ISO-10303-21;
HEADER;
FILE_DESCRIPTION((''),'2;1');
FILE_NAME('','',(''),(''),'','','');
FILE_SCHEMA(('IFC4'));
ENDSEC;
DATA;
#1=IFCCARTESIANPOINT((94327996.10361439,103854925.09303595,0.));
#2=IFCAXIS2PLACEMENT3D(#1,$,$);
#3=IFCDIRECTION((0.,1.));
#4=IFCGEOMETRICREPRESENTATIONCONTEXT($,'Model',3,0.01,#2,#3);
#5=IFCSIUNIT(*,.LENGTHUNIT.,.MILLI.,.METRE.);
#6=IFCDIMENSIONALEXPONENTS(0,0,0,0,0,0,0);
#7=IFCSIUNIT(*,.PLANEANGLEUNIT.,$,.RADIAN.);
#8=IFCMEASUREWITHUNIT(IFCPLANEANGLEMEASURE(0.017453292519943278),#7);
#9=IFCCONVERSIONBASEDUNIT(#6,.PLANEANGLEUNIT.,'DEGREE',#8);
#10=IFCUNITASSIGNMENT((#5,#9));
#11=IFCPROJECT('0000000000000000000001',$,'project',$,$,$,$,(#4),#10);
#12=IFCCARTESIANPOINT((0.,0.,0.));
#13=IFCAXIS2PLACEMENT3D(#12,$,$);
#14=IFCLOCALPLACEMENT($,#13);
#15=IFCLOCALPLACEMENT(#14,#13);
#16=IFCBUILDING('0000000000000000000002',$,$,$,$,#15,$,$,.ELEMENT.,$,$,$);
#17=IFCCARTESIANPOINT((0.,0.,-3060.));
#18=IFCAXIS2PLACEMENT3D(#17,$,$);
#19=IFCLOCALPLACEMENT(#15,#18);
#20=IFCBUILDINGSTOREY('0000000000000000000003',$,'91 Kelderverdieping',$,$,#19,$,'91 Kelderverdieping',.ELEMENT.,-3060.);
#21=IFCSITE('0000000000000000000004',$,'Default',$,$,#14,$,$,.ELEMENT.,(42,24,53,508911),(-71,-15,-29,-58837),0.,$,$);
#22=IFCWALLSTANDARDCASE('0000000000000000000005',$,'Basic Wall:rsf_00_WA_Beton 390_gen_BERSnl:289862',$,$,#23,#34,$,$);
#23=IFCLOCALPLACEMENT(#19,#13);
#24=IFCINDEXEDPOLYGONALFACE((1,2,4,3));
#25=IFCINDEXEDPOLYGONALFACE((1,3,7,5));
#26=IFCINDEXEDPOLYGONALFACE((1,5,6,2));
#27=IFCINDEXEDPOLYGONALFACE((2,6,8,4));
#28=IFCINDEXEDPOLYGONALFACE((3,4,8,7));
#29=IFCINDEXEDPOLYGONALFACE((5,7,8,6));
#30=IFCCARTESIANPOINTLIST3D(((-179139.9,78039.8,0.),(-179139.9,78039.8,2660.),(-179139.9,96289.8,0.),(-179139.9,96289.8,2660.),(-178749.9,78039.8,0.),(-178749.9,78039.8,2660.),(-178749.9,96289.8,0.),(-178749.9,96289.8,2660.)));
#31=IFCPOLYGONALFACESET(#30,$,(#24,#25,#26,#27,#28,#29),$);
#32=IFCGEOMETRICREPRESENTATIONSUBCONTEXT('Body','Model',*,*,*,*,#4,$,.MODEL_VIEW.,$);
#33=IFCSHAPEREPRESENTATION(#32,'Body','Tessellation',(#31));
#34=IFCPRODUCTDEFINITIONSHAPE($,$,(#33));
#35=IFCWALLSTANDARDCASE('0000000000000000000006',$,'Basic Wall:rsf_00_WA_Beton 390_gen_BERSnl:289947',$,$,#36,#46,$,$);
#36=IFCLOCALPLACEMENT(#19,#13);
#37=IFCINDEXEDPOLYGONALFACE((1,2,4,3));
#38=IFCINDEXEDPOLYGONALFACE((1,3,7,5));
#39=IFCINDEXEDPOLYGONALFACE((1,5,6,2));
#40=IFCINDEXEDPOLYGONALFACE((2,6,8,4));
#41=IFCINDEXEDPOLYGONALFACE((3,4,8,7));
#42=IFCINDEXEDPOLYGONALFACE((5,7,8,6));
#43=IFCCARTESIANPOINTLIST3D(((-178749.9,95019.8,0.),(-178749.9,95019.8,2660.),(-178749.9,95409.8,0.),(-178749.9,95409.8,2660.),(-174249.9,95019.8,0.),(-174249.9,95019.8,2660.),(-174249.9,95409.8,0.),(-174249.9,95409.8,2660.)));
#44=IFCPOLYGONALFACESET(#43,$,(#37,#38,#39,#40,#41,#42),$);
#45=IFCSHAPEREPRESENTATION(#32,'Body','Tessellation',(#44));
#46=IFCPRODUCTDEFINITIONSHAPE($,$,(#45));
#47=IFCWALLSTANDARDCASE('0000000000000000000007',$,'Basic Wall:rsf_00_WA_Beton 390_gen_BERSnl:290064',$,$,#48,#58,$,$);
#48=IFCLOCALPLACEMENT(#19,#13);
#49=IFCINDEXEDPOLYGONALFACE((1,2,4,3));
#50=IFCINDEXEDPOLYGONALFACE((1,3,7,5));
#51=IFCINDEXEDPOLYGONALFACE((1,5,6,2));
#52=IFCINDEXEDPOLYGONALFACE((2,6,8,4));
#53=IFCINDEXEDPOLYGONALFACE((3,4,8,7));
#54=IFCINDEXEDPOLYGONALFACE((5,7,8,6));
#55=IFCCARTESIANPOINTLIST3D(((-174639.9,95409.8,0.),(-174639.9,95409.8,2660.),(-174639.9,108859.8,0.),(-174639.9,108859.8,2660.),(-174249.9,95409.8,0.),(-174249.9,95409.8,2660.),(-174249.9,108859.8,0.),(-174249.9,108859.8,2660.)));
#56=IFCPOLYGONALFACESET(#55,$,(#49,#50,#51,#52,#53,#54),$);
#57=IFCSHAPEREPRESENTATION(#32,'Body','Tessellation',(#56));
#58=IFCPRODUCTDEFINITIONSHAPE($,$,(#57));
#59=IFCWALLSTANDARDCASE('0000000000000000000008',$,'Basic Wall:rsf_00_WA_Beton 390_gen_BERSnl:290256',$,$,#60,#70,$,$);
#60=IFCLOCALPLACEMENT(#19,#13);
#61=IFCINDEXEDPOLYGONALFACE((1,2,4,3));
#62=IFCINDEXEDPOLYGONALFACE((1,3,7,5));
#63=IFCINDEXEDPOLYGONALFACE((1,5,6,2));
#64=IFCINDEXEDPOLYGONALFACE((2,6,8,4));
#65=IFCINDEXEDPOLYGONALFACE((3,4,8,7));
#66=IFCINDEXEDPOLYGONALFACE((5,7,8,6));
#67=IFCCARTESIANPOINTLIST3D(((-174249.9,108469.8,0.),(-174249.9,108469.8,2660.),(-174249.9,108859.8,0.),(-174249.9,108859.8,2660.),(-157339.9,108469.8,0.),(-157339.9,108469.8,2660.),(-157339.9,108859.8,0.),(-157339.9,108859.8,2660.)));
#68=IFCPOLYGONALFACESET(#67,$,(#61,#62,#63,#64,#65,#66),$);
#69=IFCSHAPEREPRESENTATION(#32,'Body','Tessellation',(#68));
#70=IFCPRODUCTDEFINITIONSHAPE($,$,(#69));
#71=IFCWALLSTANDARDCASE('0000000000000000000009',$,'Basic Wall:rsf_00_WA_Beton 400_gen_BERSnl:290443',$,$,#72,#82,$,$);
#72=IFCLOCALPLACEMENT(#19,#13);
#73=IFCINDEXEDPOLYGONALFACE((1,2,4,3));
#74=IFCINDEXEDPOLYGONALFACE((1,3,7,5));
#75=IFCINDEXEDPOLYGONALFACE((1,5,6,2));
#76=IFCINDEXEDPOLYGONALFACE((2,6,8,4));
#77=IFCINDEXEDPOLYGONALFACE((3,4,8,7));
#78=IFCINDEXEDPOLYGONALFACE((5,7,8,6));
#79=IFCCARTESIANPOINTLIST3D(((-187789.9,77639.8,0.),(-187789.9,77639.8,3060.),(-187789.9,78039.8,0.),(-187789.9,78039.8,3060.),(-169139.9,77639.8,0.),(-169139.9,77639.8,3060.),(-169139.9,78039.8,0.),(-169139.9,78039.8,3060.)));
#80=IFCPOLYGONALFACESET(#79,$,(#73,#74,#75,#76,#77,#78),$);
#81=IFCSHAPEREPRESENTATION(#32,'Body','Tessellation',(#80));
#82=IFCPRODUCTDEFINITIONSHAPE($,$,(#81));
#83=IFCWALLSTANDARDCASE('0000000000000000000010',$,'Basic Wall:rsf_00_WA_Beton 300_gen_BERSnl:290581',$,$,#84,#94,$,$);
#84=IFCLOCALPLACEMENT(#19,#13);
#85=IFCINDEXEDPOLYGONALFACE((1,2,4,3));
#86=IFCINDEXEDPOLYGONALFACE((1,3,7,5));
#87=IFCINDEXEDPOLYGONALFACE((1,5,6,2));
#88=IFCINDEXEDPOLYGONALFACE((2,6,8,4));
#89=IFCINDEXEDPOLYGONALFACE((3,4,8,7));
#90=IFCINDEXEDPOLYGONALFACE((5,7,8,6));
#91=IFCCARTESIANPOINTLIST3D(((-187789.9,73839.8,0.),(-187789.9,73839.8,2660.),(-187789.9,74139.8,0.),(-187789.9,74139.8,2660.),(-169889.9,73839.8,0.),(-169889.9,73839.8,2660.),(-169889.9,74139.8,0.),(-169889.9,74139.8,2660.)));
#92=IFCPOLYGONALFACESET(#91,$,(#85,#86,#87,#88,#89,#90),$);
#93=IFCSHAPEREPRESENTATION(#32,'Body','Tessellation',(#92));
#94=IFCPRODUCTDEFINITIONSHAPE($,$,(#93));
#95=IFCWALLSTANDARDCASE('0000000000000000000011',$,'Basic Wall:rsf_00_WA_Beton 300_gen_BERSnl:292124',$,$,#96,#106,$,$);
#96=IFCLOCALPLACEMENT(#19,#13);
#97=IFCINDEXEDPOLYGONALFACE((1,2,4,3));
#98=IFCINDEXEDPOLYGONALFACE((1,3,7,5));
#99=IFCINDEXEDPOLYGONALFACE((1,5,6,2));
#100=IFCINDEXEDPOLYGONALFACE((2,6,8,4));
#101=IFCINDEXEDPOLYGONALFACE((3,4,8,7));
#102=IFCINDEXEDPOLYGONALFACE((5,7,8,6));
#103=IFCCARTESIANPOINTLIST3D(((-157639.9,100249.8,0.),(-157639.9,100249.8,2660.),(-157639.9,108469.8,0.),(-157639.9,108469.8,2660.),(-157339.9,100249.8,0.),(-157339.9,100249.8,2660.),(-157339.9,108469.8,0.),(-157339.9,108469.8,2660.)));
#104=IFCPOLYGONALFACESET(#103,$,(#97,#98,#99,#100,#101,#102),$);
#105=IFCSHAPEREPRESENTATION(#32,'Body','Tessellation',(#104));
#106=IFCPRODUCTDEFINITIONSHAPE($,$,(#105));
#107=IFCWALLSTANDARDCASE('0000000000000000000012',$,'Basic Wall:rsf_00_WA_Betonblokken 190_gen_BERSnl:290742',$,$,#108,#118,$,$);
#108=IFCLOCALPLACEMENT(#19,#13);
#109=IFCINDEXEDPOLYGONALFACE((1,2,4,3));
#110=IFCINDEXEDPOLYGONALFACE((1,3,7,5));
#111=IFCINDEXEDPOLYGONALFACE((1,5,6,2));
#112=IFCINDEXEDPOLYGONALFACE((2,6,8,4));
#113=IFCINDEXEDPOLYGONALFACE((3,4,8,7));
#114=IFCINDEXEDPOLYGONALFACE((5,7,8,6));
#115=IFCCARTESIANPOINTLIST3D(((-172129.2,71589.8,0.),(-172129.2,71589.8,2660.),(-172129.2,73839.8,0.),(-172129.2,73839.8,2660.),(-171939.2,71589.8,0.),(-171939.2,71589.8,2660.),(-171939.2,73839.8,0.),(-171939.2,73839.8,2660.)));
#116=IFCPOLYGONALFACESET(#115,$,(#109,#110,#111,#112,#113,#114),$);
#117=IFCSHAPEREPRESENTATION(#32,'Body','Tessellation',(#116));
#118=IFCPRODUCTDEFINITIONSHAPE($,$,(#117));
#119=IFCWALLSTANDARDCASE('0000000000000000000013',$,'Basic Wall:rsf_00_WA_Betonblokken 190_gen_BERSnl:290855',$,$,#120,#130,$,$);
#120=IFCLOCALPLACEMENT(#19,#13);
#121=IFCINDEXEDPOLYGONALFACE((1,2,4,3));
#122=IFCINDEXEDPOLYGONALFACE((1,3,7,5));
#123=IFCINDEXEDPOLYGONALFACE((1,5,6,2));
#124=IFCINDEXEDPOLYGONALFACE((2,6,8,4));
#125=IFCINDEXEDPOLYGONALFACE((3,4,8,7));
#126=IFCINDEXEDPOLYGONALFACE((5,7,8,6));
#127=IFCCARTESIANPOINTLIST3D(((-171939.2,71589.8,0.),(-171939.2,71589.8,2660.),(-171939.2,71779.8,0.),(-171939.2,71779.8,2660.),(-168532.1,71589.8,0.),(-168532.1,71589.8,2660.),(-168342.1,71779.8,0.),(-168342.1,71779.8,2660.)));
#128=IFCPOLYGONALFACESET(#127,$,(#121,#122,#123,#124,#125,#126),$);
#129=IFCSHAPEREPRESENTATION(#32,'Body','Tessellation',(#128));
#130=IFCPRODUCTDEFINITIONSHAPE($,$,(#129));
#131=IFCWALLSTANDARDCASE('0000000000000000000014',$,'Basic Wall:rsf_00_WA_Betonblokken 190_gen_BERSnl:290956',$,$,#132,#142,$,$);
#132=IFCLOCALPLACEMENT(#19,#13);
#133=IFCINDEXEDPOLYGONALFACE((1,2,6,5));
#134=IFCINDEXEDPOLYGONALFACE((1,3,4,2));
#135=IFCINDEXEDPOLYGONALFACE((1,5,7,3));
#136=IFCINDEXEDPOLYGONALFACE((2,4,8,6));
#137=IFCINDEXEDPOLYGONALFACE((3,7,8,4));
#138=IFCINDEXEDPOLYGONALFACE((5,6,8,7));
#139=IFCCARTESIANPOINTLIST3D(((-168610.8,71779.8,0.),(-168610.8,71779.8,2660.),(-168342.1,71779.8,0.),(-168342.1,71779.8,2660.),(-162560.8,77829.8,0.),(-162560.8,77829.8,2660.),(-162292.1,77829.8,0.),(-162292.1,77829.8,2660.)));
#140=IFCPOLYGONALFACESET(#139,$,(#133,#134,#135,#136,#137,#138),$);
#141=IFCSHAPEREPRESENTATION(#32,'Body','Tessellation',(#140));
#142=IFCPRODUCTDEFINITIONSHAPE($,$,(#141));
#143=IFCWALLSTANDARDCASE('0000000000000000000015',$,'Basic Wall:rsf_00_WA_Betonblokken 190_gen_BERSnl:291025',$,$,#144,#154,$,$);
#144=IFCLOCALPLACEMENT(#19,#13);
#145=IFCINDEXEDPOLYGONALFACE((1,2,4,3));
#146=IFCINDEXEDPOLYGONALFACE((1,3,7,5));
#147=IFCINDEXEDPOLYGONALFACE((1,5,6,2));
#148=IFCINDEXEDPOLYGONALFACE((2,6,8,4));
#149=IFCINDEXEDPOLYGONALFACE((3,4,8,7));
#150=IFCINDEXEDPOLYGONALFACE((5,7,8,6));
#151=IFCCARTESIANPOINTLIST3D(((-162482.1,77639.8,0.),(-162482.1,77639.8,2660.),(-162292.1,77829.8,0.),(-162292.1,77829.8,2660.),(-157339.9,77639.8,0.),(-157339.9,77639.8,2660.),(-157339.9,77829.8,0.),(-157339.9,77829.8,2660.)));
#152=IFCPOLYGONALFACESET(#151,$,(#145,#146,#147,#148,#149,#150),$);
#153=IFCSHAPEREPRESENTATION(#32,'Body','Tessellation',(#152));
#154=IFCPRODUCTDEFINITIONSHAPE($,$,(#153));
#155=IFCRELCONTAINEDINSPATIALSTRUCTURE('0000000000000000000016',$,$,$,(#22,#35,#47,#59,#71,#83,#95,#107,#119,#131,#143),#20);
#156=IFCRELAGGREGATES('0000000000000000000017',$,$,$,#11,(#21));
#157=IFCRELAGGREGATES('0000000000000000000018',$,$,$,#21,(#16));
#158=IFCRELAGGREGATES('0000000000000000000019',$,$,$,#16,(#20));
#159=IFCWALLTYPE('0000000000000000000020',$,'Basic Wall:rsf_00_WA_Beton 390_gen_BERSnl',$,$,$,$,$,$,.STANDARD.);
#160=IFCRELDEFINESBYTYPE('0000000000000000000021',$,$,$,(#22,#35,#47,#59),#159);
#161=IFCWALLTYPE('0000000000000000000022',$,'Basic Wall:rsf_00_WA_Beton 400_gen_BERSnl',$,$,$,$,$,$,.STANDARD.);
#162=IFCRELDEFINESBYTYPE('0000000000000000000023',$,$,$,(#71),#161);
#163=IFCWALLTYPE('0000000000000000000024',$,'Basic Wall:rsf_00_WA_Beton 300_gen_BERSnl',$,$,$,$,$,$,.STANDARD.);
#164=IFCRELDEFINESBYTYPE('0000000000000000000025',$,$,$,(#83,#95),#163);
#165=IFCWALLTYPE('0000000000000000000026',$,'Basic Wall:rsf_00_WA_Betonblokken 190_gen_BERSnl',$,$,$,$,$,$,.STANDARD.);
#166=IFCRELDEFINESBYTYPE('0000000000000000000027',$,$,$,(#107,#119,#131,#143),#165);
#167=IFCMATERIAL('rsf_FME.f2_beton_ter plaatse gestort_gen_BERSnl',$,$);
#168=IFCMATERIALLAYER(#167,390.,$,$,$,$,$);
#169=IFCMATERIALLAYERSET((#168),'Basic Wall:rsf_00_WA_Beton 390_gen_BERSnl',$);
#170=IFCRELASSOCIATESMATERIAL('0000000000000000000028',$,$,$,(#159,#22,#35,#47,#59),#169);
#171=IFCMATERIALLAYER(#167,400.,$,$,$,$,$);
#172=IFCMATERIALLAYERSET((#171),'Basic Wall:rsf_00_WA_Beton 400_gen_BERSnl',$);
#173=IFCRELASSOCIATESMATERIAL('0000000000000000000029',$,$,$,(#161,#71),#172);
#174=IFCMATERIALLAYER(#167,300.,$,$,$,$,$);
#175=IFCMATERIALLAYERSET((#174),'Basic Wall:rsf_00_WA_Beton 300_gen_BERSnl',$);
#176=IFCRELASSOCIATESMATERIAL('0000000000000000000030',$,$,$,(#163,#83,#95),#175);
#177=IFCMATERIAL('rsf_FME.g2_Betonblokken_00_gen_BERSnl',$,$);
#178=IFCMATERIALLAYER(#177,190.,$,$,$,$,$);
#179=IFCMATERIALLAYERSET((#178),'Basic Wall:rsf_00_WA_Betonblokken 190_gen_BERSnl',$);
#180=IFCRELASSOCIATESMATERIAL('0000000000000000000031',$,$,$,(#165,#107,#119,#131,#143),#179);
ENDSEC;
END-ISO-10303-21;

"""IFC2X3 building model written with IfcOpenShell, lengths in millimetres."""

from ifc_helpers import new_model, entity, si_unit, converted_unit, direction, frame, frame_2d, origin, place, context, subcontext, project, spatial, polyline, rectangle, outline, extrude, clip, bounded_halfspace, material, layer, layer_set, layer_usage, type_object, element, save


model = new_model("IFC2X3")

# Units and contexts
model_context = context("Model", 3, precision=0.01, world=frame((94327996.10361439, 103854925.09303595, 0.0)), true_north=direction((0.0, 1.0)))
body_context = subcontext(model_context, "Body", "Model", "MODEL_VIEW")
ifc_project = project(units=[si_unit("LENGTHUNIT", "METRE", prefix="MILLI"), converted_unit("PLANEANGLEUNIT", "DEGREE", entity("IfcPlaneAngleMeasure", 0.017453292519943278), si_unit("PLANEANGLEUNIT", "RADIAN"), dimensions=[0, 0, 0, 0, 0, 0, 0])], contexts=[model_context])

# Site, building, storey
site_placement = place(None, origin())
site = spatial("IfcSite", under=ifc_project, at=site_placement, Name="Default", CompositionType="ELEMENT", RefLatitude=(42, 24, 53, 508911), RefLongitude=(-71, -15, -29, -58837), RefElevation=0.0)
building_placement = place(site_placement, origin())
building = spatial("IfcBuilding", under=site, at=building_placement, CompositionType="ELEMENT")
storey_placement = place(building_placement, frame((0.0, 0.0, -3060.0)))
storey = spatial("IfcBuildingStorey", under=building, at=storey_placement, Name="91 Kelderverdieping", LongName="91 Kelderverdieping", CompositionType="ELEMENT", Elevation=-3060.0)

# Shared definitions
ifc_material_1 = material(Name="rsf_FME.f2_beton_ter plaatse gestort_gen_BERSnl")

# Walls
ifc_layer_1 = layer(ifc_material_1, 390.0)
ifc_layer_set_1 = layer_set([ifc_layer_1], Name="Basic Wall:rsf_00_WA_Beton 390_gen_BERSnl")
ifc_layer_usage_1 = layer_usage(ifc_layer_set_1, "AXIS2", "NEGATIVE", 195.0)
wall_type_1 = type_object("IfcWallType", Name="Basic Wall:rsf_00_WA_Beton 390_gen_BERSnl", PredefinedType="STANDARD", material=ifc_layer_set_1)
wall_1_placement = place(storey_placement, frame((-178944.9, 78039.8, 0.0), z_axis=(0.0, 0.0, 1.0), x_axis=(0.0, 1.0, 0.0)))
element("IfcWallStandardCase", 1, at=wall_1_placement, inside=storey, type_object=wall_type_1, material=ifc_layer_usage_1, Name="Basic Wall:rsf_00_WA_Beton 390_gen_BERSnl:289862", context=body_context, shape_type="Clipping", body=[
    clip(extrude(rectangle(XDim=18250.0, YDim=390.0, at=frame_2d((9125.0, 0.0), x_axis=(-1.0, 0.0))), origin(), (0.0, 0.0, 1.0), 2660.0), bounded_halfspace(frame((0.0, -195.0, 2660.0), z_axis=(0.0, 0.0, -1.0), x_axis=(0.0, 1.0, 0.0)), True, frame((0.0, -195.0, 2660.0)), polyline([(0.0, 0.0), (16980.0, 0.0), (17370.0, 0.0), (18250.0, 0.0), (18250.0, 390.0), (0.0, 390.0), (0.0, 0.0)]))),
])
ifc_layer_usage_2 = layer_usage(ifc_layer_set_1, "AXIS2", "NEGATIVE", 195.0)
wall_2_placement = place(storey_placement, frame((-178749.9, 95214.8, 0.0)))
element("IfcWallStandardCase", 2, at=wall_2_placement, inside=storey, type_object=wall_type_1, material=ifc_layer_usage_2, Name="Basic Wall:rsf_00_WA_Beton 390_gen_BERSnl:289947", context=body_context, shape_type="Clipping", body=[
    clip(extrude(rectangle(XDim=4500.0, YDim=390.0, at=frame_2d((2250.0, 0.0), x_axis=(-1.0, 0.0))), origin(), (0.0, 0.0, 1.0), 2660.0), bounded_halfspace(frame((0.0, -195.0, 2660.0), z_axis=(0.0, 0.0, -1.0), x_axis=(-1.0, 0.0, 0.0)), True, frame((0.0, -195.0, 2660.0)), polyline([(0.0, 0.0), (4500.0, 0.0), (4500.0, 390.0), (4110.0, 390.0), (0.0, 390.0), (0.0, 0.0)]))),
])
ifc_layer_usage_3 = layer_usage(ifc_layer_set_1, "AXIS2", "NEGATIVE", 195.0)
wall_3_placement = place(storey_placement, frame((-174444.9, 95409.8, 0.0), z_axis=(0.0, 0.0, 1.0), x_axis=(0.0, 1.0, 0.0)))
element("IfcWallStandardCase", 3, at=wall_3_placement, inside=storey, type_object=wall_type_1, material=ifc_layer_usage_3, Name="Basic Wall:rsf_00_WA_Beton 390_gen_BERSnl:290064", context=body_context, shape_type="Clipping", body=[
    clip(extrude(rectangle(XDim=13450.0, YDim=390.0, at=frame_2d((6725.0, 0.0), x_axis=(-1.0, 0.0))), origin(), (0.0, 0.0, 1.0), 2660.0), bounded_halfspace(frame((0.0, -195.0, 2660.0), z_axis=(0.0, 0.0, -1.0), x_axis=(0.0, 1.0, 0.0)), True, frame((0.0, -195.0, 2660.0)), polyline([(0.0, 0.0), (13060.0, 0.0), (13450.0, 0.0), (13450.0, 390.0), (990.0, 390.0), (0.0, 390.0), (0.0, 0.0)]))),
])
ifc_layer_usage_4 = layer_usage(ifc_layer_set_1, "AXIS2", "NEGATIVE", 195.0)
wall_4_placement = place(storey_placement, frame((-174249.9, 108664.8, 0.0)))
element("IfcWallStandardCase", 4, at=wall_4_placement, inside=storey, type_object=wall_type_1, material=ifc_layer_usage_4, Name="Basic Wall:rsf_00_WA_Beton 390_gen_BERSnl:290256", context=body_context, shape_type="Clipping", body=[
    clip(extrude(rectangle(XDim=16910.0, YDim=390.0, at=frame_2d((8455.0, 0.0), x_axis=(-1.0, 0.0))), origin(), (0.0, 0.0, 1.0), 2660.0), bounded_halfspace(frame((0.0, -195.0, 2660.0), z_axis=(0.0, 0.0, -1.0), x_axis=(-1.0, 0.0, 0.0)), True, frame((0.0, -195.0, 2660.0)), polyline([(0.0, 0.0), (16610.0, 0.0), (16910.0, 0.0), (16910.0, 390.0), (15570.0, 390.0), (15180.0, 390.0), (0.0, 390.0), (0.0, 0.0)]))),
])
ifc_layer_2 = layer(ifc_material_1, 400.0)
ifc_layer_set_2 = layer_set([ifc_layer_2], Name="Basic Wall:rsf_00_WA_Beton 400_gen_BERSnl")
ifc_layer_usage_5 = layer_usage(ifc_layer_set_2, "AXIS2", "NEGATIVE", 200.0)
wall_type_2 = type_object("IfcWallType", Name="Basic Wall:rsf_00_WA_Beton 400_gen_BERSnl", PredefinedType="STANDARD", material=ifc_layer_set_2)
wall_5_placement = place(storey_placement, frame((-187789.9, 77839.8, 0.0)))
element("IfcWallStandardCase", 5, at=wall_5_placement, inside=storey, type_object=wall_type_2, material=ifc_layer_usage_5, Name="Basic Wall:rsf_00_WA_Beton 400_gen_BERSnl:290443", context=body_context, shape_type="SweptSolid", body=[
    extrude(rectangle(XDim=18650.0, YDim=400.0, at=frame_2d((9325.0, 0.0), x_axis=(-1.0, 0.0))), origin(), (0.0, 0.0, 1.0), 3060.0),
])
ifc_layer_3 = layer(ifc_material_1, 300.0)
ifc_layer_set_3 = layer_set([ifc_layer_3], Name="Basic Wall:rsf_00_WA_Beton 300_gen_BERSnl")
ifc_layer_usage_6 = layer_usage(ifc_layer_set_3, "AXIS2", "NEGATIVE", 150.0)
wall_type_3 = type_object("IfcWallType", Name="Basic Wall:rsf_00_WA_Beton 300_gen_BERSnl", PredefinedType="STANDARD", material=ifc_layer_set_3)
wall_6_placement = place(storey_placement, frame((-187789.9, 73989.8, 0.0)))
element("IfcWallStandardCase", 6, at=wall_6_placement, inside=storey, type_object=wall_type_3, material=ifc_layer_usage_6, Name="Basic Wall:rsf_00_WA_Beton 300_gen_BERSnl:290581", context=body_context, shape_type="SweptSolid", body=[
    extrude(rectangle(XDim=17900.0, YDim=300.0, at=frame_2d((8950.0, 0.0), x_axis=(-1.0, 0.0))), origin(), (0.0, 0.0, 1.0), 2660.0),
])
ifc_layer_usage_7 = layer_usage(ifc_layer_set_3, "AXIS2", "NEGATIVE", 150.0)
wall_7_placement = place(storey_placement, frame((-157489.9, 108469.8, 0.0), z_axis=(0.0, 0.0, 1.0), x_axis=(0.0, -1.0, 0.0)))
element("IfcWallStandardCase", 7, at=wall_7_placement, inside=storey, type_object=wall_type_3, material=ifc_layer_usage_7, Name="Basic Wall:rsf_00_WA_Beton 300_gen_BERSnl:292124", context=body_context, shape_type="Clipping", body=[
    clip(extrude(rectangle(XDim=8220.0, YDim=300.0, at=frame_2d((4110.0, 0.0), x_axis=(-1.0, 0.0))), origin(), (0.0, 0.0, 1.0), 2660.0), bounded_halfspace(frame((0.0, -150.0, 2660.0), z_axis=(0.0, 0.0, -1.0), x_axis=(0.0, -1.0, 0.0)), True, frame((0.0, -150.0, 2660.0)), polyline([(0.0, 0.0), (8220.0, 0.0), (8220.0, 110.0), (8220.0, 300.0), (0.0, 300.0), (0.0, 0.0)]))),
])
ifc_material_2 = material(Name="rsf_FME.g2_Betonblokken_00_gen_BERSnl")
ifc_layer_4 = layer(ifc_material_2, 190.0)
ifc_layer_set_4 = layer_set([ifc_layer_4], Name="Basic Wall:rsf_00_WA_Betonblokken 190_gen_BERSnl")
ifc_layer_usage_8 = layer_usage(ifc_layer_set_4, "AXIS2", "POSITIVE", -95.0)
wall_type_4 = type_object("IfcWallType", Name="Basic Wall:rsf_00_WA_Betonblokken 190_gen_BERSnl", PredefinedType="STANDARD", material=ifc_layer_set_4)
wall_8_placement = place(storey_placement, frame((-172034.2, 73839.8, 0.0), z_axis=(0.0, 0.0, 1.0), x_axis=(0.0, -1.0, 0.0)))
element("IfcWallStandardCase", 8, at=wall_8_placement, inside=storey, type_object=wall_type_4, material=ifc_layer_usage_8, Name="Basic Wall:rsf_00_WA_Betonblokken 190_gen_BERSnl:290742", context=body_context, shape_type="Clipping", body=[
    clip(extrude(rectangle(XDim=2250.0, YDim=190.0, at=frame_2d((1125.0, 0.0), x_axis=(-1.0, 0.0))), origin(), (0.0, 0.0, 1.0), 2660.0), bounded_halfspace(frame((0.0, -95.0, 2660.0), z_axis=(0.0, 0.0, -1.0), x_axis=(0.0, -1.0, 0.0)), True, frame((0.0, -95.0, 2660.0)), polyline([(0.0, 0.0), (2250.0, 0.0), (2250.0, 190.0), (2060.0, 190.0), (0.0, 190.0), (0.0, 0.0)]))),
])
ifc_layer_usage_9 = layer_usage(ifc_layer_set_4, "AXIS2", "POSITIVE", -95.0)
wall_9_placement = place(storey_placement, frame((-171939.2, 71684.8, 0.0)))
element("IfcWallStandardCase", 9, at=wall_9_placement, inside=storey, type_object=wall_type_4, material=ifc_layer_usage_9, Name="Basic Wall:rsf_00_WA_Betonblokken 190_gen_BERSnl:290855", context=body_context, shape_type="Clipping", body=[
    clip(extrude(outline(polyline([(3407.1, -95.0), (3597.1, 95.0), (3328.4, 95.0), (0.0, 95.0), (0.0, -95.0), (3407.1, -95.0)])), origin(), (0.0, 0.0, 1.0), 2660.0), bounded_halfspace(frame((0.0, -95.0, 2660.0), z_axis=(0.0, 0.0, -1.0), x_axis=(-1.0, 0.0, 0.0)), True, frame((0.0, -95.0, 2660.0)), polyline([(0.0, 0.0), (3407.1, 0.0), (3597.1, 190.0), (3328.4, 190.0), (0.0, 190.0), (0.0, 0.0)]))),
])
ifc_layer_usage_10 = layer_usage(ifc_layer_set_4, "AXIS2", "POSITIVE", -95.0)
wall_10_placement = place(storey_placement, frame((-168543.7, 71712.6, 0.0), z_axis=(0.0, 0.0, 1.0), x_axis=(0.707107, 0.707107, 0.0)))
element("IfcWallStandardCase", 10, at=wall_10_placement, inside=storey, type_object=wall_type_4, material=ifc_layer_usage_10, Name="Basic Wall:rsf_00_WA_Betonblokken 190_gen_BERSnl:290956", context=body_context, shape_type="Clipping", body=[
    clip(extrude(outline(polyline([(8746.0, -95.0), (8556.0, 95.0), (0.0, 95.0), (190.0, -95.0), (8477.3, -95.0), (8746.0, -95.0)])), origin(), (0.0, 0.0, 1.0), 2660.0), bounded_halfspace(frame((190.0, -95.0, 2660.0), z_axis=(0.0, 0.0, -1.0), x_axis=(-0.707107, 0.707107, 0.0)), True, frame((190.0, -95.0, 2660.0)), polyline([(0.0, 0.0), (8287.3, 0.0), (8556.0, 0.0), (8366.0, 190.0), (-190.0, 190.0), (0.0, 0.0)]))),
])
ifc_layer_usage_11 = layer_usage(ifc_layer_set_4, "AXIS2", "POSITIVE", -95.0)
wall_11_placement = place(storey_placement, frame((-162482.1, 77734.8, 0.0)))
element("IfcWallStandardCase", 11, at=wall_11_placement, inside=storey, type_object=wall_type_4, material=ifc_layer_usage_11, Name="Basic Wall:rsf_00_WA_Betonblokken 190_gen_BERSnl:291025", context=body_context, shape_type="Clipping", body=[
    clip(extrude(outline(polyline([(5142.3, -95.0), (5142.3, 95.0), (4952.3, 95.0), (190.0, 95.0), (0.0, -95.0), (5142.3, -95.0)])), origin(), (0.0, 0.0, 1.0), 2660.0), bounded_halfspace(frame((0.0, -95.0, 2660.0), z_axis=(0.0, 0.0, -1.0), x_axis=(-1.0, 0.0, 0.0)), True, frame((0.0, -95.0, 2660.0)), polyline([(0.0, 0.0), (5142.3, 0.0), (5142.3, 190.0), (4952.3, 190.0), (190.0, 190.0), (0.0, 0.0)]))),
])

save(model, "model.ifc")
